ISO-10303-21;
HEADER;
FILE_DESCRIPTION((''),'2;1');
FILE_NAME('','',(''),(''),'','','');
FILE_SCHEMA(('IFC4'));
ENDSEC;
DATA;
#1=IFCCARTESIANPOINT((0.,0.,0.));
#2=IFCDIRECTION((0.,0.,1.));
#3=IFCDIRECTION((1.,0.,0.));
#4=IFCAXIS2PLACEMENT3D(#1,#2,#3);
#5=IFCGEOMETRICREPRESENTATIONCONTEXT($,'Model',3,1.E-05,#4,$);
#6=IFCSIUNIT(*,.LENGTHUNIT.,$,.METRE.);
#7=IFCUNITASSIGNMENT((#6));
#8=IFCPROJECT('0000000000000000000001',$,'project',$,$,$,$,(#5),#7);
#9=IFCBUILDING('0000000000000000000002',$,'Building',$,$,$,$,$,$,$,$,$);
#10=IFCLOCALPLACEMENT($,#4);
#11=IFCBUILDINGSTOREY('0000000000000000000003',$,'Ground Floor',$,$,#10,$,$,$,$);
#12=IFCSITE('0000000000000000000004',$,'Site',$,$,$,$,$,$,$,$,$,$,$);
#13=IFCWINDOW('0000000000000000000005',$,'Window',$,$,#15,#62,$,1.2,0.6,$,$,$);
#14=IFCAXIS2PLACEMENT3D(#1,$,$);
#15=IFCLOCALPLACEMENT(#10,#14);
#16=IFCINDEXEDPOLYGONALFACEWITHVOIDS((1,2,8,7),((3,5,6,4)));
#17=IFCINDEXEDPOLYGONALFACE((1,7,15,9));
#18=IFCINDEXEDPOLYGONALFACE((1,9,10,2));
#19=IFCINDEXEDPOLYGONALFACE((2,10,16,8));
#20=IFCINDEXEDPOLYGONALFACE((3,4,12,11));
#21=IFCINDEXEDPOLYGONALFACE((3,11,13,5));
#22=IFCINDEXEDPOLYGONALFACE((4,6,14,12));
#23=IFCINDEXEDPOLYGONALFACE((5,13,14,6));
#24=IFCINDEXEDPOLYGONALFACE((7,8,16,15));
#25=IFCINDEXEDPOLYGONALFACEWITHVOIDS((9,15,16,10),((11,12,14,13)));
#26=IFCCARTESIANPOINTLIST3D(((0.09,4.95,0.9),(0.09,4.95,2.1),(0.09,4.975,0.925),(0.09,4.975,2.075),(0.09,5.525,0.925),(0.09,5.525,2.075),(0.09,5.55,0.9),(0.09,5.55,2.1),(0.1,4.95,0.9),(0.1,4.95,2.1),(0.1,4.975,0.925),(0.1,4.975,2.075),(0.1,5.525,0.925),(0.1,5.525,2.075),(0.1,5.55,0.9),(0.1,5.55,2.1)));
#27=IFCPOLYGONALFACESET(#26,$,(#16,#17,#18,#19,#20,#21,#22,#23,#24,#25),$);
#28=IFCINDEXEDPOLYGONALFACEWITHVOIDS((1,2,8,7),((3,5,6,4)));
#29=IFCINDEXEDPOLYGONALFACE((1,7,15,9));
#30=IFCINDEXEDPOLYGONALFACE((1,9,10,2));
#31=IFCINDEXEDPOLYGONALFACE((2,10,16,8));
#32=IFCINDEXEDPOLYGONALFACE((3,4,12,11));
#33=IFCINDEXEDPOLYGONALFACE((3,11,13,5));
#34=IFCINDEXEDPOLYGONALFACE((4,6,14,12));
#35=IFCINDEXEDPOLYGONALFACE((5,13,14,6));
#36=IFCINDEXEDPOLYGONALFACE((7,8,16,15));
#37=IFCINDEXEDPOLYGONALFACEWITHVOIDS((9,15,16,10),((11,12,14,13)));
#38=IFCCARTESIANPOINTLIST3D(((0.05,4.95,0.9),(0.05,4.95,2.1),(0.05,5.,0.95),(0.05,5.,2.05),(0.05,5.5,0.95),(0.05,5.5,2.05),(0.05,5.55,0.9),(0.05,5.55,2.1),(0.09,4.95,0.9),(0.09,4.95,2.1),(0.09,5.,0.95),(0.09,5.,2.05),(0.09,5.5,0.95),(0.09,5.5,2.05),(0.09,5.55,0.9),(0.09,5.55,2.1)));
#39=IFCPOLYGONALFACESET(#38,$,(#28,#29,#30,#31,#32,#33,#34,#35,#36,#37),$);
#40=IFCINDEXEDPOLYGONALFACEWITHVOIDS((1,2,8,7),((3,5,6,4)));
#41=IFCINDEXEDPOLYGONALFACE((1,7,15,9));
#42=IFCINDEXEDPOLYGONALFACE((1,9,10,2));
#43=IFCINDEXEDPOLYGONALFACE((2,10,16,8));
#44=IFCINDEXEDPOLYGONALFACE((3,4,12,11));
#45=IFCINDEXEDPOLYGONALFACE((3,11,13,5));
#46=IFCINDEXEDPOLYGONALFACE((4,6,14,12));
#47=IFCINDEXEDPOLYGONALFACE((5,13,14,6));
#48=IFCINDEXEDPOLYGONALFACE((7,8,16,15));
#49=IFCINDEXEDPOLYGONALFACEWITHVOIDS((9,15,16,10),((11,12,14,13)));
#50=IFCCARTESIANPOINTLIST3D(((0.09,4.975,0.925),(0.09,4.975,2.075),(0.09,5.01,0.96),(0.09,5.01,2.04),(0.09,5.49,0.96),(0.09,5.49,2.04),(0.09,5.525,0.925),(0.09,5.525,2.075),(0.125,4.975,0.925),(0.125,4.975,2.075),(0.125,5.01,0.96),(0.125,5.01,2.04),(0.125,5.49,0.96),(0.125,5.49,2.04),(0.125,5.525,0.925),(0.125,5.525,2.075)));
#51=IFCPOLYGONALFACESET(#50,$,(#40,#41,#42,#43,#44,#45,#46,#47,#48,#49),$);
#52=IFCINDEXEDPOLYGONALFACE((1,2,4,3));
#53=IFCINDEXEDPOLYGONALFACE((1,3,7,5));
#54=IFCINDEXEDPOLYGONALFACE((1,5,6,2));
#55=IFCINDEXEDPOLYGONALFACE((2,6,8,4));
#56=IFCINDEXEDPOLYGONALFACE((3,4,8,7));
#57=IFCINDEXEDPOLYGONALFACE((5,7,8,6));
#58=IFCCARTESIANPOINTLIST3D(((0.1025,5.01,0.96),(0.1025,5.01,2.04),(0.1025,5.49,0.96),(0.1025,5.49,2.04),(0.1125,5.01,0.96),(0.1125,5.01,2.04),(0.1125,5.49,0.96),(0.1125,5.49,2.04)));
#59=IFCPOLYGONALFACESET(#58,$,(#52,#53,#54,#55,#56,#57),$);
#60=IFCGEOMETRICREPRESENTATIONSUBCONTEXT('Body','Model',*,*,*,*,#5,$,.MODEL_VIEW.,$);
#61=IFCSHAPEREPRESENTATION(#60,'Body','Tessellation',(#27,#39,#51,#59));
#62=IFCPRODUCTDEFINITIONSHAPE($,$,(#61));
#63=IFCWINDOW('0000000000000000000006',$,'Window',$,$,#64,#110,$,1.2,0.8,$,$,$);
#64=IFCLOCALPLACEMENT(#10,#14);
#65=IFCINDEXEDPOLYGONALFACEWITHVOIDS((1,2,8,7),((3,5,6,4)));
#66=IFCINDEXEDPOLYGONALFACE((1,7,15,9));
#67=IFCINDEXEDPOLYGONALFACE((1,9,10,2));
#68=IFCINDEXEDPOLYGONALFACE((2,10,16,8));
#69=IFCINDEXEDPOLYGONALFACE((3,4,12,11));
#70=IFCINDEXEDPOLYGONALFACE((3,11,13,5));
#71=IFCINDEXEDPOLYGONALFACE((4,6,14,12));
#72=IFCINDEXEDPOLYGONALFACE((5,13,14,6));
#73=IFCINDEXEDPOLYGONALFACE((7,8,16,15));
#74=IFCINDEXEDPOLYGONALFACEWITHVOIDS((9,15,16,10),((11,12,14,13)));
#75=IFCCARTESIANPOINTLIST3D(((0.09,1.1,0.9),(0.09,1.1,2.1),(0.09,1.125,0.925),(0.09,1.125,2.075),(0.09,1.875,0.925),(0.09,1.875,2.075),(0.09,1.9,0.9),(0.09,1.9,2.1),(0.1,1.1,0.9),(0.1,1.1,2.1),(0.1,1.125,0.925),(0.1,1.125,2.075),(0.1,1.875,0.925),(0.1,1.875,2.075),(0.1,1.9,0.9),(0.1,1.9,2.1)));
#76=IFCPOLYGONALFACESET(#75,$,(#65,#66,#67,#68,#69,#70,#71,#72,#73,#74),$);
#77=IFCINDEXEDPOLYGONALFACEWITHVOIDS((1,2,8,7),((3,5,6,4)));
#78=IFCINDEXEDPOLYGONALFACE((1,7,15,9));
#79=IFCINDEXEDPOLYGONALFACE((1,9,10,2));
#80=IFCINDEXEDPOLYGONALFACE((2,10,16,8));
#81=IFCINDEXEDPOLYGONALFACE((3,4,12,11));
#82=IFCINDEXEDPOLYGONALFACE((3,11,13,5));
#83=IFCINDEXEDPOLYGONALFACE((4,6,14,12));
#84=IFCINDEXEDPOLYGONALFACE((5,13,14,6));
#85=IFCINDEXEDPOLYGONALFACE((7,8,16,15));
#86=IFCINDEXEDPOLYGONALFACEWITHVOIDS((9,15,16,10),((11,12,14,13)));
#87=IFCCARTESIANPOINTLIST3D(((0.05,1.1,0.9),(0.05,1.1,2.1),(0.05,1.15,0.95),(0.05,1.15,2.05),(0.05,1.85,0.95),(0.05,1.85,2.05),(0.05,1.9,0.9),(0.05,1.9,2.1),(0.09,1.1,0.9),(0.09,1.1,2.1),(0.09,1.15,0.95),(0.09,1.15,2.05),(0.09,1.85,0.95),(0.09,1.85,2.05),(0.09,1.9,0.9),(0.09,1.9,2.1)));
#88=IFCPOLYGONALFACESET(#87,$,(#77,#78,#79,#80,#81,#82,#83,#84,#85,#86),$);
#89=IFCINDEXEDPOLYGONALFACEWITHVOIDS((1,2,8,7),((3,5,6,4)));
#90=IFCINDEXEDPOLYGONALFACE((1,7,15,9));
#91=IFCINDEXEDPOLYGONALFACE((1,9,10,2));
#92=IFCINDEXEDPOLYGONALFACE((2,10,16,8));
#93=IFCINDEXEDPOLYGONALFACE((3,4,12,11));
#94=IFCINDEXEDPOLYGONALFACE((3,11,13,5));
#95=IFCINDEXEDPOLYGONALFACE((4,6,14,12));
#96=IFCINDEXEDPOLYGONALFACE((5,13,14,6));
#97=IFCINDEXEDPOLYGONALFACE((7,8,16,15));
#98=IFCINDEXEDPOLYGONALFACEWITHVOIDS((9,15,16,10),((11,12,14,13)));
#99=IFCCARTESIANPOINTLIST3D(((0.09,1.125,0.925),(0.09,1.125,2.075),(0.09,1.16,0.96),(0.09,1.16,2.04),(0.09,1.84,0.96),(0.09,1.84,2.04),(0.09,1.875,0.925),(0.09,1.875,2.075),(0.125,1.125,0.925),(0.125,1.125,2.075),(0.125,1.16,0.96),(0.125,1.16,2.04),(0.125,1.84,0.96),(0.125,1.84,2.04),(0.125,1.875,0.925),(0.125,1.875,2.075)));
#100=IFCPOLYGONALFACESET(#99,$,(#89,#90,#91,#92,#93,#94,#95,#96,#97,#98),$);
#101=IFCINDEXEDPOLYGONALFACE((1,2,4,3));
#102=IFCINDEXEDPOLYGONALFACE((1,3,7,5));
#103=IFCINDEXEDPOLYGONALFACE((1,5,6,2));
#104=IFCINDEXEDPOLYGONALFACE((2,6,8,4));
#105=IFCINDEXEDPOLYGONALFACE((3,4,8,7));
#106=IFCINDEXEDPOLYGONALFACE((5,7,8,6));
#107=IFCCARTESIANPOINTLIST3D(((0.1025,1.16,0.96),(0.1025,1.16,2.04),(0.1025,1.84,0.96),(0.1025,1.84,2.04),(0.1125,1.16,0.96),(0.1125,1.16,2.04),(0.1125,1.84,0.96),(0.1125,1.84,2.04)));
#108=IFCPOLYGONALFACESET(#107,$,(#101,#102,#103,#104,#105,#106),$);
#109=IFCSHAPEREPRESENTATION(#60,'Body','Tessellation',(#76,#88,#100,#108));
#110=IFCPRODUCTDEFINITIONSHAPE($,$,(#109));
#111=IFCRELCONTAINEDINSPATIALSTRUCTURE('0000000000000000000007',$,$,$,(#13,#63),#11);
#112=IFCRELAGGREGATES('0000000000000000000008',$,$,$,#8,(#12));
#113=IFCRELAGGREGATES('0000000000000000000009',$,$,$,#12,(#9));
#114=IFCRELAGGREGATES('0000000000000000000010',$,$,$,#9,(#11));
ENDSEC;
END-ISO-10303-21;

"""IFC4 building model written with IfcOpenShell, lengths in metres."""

from ifc_helpers import new_model, si_unit, frame, origin_with_axes, place, context, subcontext, project, spatial, line, indexed_curve, outline, extrude, element, save


model = new_model("IFC4")

# Units and contexts
model_context = context("Model", 3, precision=1e-05, world=origin_with_axes())
body_context = subcontext(model_context, "Body", "Model", "MODEL_VIEW")
ifc_project = project(units=[si_unit("LENGTHUNIT", "METRE")], contexts=[model_context])

# Site, building, storey
site = spatial("IfcSite", under=ifc_project, Name="Site")
building = spatial("IfcBuilding", under=site, Name="Building")
storey_placement = place(None, origin_with_axes())
storey = spatial("IfcBuildingStorey", under=building, at=storey_placement, Name="Ground Floor")

# Windows
window_1_placement = place(storey_placement, frame((0.0, 5.55, 0.9), z_axis=(0.0, 0.0, 1.0), x_axis=(0.0, -1.0, 0.0)))
element("IfcWindow", 1, at=window_1_placement, inside=storey, Name="Window", OverallHeight=1.2, OverallWidth=0.6, context=body_context, shape_type="SweptSolid", body=[
    extrude(outline(indexed_curve([(0.0, 0.0), (0.6, 0.0), (0.6, 1.2), (0.0, 1.2)], segments=[line(1, 2, 3, 4, 1)]), holes=[indexed_curve([(0.025, 0.025), (0.575, 0.025), (0.575, 1.175), (0.025, 1.175)], segments=[line(1, 2, 3, 4, 1)])]), frame((0.0, 0.09, 0.0), z_axis=(0.0, -1.0, 0.0), x_axis=(1.0, 0.0, 0.0)), (0.0, 0.0, -1.0), 0.01),
    extrude(outline(indexed_curve([(0.0, 0.0), (0.6, 0.0), (0.6, 1.2), (0.0, 1.2)], segments=[line(1, 2, 3, 4, 1)]), holes=[indexed_curve([(0.05, 0.05), (0.55, 0.05), (0.55, 1.15), (0.05, 1.15)], segments=[line(1, 2, 3, 4, 1)])]), frame((0.0, 0.05, 0.0), z_axis=(0.0, -1.0, 0.0), x_axis=(1.0, 0.0, 0.0)), (0.0, 0.0, -1.0), 0.04),
    extrude(outline(indexed_curve([(0.0, 0.0), (0.55, 0.0), (0.55, 1.15), (0.0, 1.15)], segments=[line(1, 2, 3, 4, 1)]), holes=[indexed_curve([(0.035, 0.035), (0.515, 0.035), (0.515, 1.115), (0.035, 1.115)], segments=[line(1, 2, 3, 4, 1)])]), frame((0.025, 0.09, 0.025), z_axis=(0.0, -1.0, 0.0), x_axis=(1.0, 0.0, 0.0)), (0.0, 0.0, -1.0), 0.035),
    extrude(outline(indexed_curve([(0.035, 0.035), (0.515, 0.035), (0.515, 1.115), (0.035, 1.115)], segments=[line(1, 2, 3, 4, 1)])), frame((0.025, 0.1025, 0.025), z_axis=(0.0, -1.0, 0.0), x_axis=(1.0, 0.0, 0.0)), (0.0, 0.0, -1.0), 0.01),
])
window_2_placement = place(storey_placement, frame((0.0, 1.9, 0.9), z_axis=(0.0, 0.0, 1.0), x_axis=(0.0, -1.0, 0.0)))
element("IfcWindow", 2, at=window_2_placement, inside=storey, Name="Window", OverallHeight=1.2, OverallWidth=0.8, context=body_context, shape_type="SweptSolid", body=[
    extrude(outline(indexed_curve([(0.0, 0.0), (0.8, 0.0), (0.8, 1.2), (0.0, 1.2)], segments=[line(1, 2, 3, 4, 1)]), holes=[indexed_curve([(0.025, 0.025), (0.775, 0.025), (0.775, 1.175), (0.025, 1.175)], segments=[line(1, 2, 3, 4, 1)])]), frame((0.0, 0.09, 0.0), z_axis=(0.0, -1.0, 0.0), x_axis=(1.0, 0.0, 0.0)), (0.0, 0.0, -1.0), 0.01),
    extrude(outline(indexed_curve([(0.0, 0.0), (0.8, 0.0), (0.8, 1.2), (0.0, 1.2)], segments=[line(1, 2, 3, 4, 1)]), holes=[indexed_curve([(0.05, 0.05), (0.75, 0.05), (0.75, 1.15), (0.05, 1.15)], segments=[line(1, 2, 3, 4, 1)])]), frame((0.0, 0.05, 0.0), z_axis=(0.0, -1.0, 0.0), x_axis=(1.0, 0.0, 0.0)), (0.0, 0.0, -1.0), 0.04),
    extrude(outline(indexed_curve([(0.0, 0.0), (0.75, 0.0), (0.75, 1.15), (0.0, 1.15)], segments=[line(1, 2, 3, 4, 1)]), holes=[indexed_curve([(0.035, 0.035), (0.715, 0.035), (0.715, 1.115), (0.035, 1.115)], segments=[line(1, 2, 3, 4, 1)])]), frame((0.025, 0.09, 0.025), z_axis=(0.0, -1.0, 0.0), x_axis=(1.0, 0.0, 0.0)), (0.0, 0.0, -1.0), 0.035),
    extrude(outline(indexed_curve([(0.035, 0.035), (0.715, 0.035), (0.715, 1.115), (0.035, 1.115)], segments=[line(1, 2, 3, 4, 1)])), frame((0.025, 0.1025, 0.025), z_axis=(0.0, -1.0, 0.0), x_axis=(1.0, 0.0, 0.0)), (0.0, 0.0, -1.0), 0.01),
])

save(model, "model.ifc")
